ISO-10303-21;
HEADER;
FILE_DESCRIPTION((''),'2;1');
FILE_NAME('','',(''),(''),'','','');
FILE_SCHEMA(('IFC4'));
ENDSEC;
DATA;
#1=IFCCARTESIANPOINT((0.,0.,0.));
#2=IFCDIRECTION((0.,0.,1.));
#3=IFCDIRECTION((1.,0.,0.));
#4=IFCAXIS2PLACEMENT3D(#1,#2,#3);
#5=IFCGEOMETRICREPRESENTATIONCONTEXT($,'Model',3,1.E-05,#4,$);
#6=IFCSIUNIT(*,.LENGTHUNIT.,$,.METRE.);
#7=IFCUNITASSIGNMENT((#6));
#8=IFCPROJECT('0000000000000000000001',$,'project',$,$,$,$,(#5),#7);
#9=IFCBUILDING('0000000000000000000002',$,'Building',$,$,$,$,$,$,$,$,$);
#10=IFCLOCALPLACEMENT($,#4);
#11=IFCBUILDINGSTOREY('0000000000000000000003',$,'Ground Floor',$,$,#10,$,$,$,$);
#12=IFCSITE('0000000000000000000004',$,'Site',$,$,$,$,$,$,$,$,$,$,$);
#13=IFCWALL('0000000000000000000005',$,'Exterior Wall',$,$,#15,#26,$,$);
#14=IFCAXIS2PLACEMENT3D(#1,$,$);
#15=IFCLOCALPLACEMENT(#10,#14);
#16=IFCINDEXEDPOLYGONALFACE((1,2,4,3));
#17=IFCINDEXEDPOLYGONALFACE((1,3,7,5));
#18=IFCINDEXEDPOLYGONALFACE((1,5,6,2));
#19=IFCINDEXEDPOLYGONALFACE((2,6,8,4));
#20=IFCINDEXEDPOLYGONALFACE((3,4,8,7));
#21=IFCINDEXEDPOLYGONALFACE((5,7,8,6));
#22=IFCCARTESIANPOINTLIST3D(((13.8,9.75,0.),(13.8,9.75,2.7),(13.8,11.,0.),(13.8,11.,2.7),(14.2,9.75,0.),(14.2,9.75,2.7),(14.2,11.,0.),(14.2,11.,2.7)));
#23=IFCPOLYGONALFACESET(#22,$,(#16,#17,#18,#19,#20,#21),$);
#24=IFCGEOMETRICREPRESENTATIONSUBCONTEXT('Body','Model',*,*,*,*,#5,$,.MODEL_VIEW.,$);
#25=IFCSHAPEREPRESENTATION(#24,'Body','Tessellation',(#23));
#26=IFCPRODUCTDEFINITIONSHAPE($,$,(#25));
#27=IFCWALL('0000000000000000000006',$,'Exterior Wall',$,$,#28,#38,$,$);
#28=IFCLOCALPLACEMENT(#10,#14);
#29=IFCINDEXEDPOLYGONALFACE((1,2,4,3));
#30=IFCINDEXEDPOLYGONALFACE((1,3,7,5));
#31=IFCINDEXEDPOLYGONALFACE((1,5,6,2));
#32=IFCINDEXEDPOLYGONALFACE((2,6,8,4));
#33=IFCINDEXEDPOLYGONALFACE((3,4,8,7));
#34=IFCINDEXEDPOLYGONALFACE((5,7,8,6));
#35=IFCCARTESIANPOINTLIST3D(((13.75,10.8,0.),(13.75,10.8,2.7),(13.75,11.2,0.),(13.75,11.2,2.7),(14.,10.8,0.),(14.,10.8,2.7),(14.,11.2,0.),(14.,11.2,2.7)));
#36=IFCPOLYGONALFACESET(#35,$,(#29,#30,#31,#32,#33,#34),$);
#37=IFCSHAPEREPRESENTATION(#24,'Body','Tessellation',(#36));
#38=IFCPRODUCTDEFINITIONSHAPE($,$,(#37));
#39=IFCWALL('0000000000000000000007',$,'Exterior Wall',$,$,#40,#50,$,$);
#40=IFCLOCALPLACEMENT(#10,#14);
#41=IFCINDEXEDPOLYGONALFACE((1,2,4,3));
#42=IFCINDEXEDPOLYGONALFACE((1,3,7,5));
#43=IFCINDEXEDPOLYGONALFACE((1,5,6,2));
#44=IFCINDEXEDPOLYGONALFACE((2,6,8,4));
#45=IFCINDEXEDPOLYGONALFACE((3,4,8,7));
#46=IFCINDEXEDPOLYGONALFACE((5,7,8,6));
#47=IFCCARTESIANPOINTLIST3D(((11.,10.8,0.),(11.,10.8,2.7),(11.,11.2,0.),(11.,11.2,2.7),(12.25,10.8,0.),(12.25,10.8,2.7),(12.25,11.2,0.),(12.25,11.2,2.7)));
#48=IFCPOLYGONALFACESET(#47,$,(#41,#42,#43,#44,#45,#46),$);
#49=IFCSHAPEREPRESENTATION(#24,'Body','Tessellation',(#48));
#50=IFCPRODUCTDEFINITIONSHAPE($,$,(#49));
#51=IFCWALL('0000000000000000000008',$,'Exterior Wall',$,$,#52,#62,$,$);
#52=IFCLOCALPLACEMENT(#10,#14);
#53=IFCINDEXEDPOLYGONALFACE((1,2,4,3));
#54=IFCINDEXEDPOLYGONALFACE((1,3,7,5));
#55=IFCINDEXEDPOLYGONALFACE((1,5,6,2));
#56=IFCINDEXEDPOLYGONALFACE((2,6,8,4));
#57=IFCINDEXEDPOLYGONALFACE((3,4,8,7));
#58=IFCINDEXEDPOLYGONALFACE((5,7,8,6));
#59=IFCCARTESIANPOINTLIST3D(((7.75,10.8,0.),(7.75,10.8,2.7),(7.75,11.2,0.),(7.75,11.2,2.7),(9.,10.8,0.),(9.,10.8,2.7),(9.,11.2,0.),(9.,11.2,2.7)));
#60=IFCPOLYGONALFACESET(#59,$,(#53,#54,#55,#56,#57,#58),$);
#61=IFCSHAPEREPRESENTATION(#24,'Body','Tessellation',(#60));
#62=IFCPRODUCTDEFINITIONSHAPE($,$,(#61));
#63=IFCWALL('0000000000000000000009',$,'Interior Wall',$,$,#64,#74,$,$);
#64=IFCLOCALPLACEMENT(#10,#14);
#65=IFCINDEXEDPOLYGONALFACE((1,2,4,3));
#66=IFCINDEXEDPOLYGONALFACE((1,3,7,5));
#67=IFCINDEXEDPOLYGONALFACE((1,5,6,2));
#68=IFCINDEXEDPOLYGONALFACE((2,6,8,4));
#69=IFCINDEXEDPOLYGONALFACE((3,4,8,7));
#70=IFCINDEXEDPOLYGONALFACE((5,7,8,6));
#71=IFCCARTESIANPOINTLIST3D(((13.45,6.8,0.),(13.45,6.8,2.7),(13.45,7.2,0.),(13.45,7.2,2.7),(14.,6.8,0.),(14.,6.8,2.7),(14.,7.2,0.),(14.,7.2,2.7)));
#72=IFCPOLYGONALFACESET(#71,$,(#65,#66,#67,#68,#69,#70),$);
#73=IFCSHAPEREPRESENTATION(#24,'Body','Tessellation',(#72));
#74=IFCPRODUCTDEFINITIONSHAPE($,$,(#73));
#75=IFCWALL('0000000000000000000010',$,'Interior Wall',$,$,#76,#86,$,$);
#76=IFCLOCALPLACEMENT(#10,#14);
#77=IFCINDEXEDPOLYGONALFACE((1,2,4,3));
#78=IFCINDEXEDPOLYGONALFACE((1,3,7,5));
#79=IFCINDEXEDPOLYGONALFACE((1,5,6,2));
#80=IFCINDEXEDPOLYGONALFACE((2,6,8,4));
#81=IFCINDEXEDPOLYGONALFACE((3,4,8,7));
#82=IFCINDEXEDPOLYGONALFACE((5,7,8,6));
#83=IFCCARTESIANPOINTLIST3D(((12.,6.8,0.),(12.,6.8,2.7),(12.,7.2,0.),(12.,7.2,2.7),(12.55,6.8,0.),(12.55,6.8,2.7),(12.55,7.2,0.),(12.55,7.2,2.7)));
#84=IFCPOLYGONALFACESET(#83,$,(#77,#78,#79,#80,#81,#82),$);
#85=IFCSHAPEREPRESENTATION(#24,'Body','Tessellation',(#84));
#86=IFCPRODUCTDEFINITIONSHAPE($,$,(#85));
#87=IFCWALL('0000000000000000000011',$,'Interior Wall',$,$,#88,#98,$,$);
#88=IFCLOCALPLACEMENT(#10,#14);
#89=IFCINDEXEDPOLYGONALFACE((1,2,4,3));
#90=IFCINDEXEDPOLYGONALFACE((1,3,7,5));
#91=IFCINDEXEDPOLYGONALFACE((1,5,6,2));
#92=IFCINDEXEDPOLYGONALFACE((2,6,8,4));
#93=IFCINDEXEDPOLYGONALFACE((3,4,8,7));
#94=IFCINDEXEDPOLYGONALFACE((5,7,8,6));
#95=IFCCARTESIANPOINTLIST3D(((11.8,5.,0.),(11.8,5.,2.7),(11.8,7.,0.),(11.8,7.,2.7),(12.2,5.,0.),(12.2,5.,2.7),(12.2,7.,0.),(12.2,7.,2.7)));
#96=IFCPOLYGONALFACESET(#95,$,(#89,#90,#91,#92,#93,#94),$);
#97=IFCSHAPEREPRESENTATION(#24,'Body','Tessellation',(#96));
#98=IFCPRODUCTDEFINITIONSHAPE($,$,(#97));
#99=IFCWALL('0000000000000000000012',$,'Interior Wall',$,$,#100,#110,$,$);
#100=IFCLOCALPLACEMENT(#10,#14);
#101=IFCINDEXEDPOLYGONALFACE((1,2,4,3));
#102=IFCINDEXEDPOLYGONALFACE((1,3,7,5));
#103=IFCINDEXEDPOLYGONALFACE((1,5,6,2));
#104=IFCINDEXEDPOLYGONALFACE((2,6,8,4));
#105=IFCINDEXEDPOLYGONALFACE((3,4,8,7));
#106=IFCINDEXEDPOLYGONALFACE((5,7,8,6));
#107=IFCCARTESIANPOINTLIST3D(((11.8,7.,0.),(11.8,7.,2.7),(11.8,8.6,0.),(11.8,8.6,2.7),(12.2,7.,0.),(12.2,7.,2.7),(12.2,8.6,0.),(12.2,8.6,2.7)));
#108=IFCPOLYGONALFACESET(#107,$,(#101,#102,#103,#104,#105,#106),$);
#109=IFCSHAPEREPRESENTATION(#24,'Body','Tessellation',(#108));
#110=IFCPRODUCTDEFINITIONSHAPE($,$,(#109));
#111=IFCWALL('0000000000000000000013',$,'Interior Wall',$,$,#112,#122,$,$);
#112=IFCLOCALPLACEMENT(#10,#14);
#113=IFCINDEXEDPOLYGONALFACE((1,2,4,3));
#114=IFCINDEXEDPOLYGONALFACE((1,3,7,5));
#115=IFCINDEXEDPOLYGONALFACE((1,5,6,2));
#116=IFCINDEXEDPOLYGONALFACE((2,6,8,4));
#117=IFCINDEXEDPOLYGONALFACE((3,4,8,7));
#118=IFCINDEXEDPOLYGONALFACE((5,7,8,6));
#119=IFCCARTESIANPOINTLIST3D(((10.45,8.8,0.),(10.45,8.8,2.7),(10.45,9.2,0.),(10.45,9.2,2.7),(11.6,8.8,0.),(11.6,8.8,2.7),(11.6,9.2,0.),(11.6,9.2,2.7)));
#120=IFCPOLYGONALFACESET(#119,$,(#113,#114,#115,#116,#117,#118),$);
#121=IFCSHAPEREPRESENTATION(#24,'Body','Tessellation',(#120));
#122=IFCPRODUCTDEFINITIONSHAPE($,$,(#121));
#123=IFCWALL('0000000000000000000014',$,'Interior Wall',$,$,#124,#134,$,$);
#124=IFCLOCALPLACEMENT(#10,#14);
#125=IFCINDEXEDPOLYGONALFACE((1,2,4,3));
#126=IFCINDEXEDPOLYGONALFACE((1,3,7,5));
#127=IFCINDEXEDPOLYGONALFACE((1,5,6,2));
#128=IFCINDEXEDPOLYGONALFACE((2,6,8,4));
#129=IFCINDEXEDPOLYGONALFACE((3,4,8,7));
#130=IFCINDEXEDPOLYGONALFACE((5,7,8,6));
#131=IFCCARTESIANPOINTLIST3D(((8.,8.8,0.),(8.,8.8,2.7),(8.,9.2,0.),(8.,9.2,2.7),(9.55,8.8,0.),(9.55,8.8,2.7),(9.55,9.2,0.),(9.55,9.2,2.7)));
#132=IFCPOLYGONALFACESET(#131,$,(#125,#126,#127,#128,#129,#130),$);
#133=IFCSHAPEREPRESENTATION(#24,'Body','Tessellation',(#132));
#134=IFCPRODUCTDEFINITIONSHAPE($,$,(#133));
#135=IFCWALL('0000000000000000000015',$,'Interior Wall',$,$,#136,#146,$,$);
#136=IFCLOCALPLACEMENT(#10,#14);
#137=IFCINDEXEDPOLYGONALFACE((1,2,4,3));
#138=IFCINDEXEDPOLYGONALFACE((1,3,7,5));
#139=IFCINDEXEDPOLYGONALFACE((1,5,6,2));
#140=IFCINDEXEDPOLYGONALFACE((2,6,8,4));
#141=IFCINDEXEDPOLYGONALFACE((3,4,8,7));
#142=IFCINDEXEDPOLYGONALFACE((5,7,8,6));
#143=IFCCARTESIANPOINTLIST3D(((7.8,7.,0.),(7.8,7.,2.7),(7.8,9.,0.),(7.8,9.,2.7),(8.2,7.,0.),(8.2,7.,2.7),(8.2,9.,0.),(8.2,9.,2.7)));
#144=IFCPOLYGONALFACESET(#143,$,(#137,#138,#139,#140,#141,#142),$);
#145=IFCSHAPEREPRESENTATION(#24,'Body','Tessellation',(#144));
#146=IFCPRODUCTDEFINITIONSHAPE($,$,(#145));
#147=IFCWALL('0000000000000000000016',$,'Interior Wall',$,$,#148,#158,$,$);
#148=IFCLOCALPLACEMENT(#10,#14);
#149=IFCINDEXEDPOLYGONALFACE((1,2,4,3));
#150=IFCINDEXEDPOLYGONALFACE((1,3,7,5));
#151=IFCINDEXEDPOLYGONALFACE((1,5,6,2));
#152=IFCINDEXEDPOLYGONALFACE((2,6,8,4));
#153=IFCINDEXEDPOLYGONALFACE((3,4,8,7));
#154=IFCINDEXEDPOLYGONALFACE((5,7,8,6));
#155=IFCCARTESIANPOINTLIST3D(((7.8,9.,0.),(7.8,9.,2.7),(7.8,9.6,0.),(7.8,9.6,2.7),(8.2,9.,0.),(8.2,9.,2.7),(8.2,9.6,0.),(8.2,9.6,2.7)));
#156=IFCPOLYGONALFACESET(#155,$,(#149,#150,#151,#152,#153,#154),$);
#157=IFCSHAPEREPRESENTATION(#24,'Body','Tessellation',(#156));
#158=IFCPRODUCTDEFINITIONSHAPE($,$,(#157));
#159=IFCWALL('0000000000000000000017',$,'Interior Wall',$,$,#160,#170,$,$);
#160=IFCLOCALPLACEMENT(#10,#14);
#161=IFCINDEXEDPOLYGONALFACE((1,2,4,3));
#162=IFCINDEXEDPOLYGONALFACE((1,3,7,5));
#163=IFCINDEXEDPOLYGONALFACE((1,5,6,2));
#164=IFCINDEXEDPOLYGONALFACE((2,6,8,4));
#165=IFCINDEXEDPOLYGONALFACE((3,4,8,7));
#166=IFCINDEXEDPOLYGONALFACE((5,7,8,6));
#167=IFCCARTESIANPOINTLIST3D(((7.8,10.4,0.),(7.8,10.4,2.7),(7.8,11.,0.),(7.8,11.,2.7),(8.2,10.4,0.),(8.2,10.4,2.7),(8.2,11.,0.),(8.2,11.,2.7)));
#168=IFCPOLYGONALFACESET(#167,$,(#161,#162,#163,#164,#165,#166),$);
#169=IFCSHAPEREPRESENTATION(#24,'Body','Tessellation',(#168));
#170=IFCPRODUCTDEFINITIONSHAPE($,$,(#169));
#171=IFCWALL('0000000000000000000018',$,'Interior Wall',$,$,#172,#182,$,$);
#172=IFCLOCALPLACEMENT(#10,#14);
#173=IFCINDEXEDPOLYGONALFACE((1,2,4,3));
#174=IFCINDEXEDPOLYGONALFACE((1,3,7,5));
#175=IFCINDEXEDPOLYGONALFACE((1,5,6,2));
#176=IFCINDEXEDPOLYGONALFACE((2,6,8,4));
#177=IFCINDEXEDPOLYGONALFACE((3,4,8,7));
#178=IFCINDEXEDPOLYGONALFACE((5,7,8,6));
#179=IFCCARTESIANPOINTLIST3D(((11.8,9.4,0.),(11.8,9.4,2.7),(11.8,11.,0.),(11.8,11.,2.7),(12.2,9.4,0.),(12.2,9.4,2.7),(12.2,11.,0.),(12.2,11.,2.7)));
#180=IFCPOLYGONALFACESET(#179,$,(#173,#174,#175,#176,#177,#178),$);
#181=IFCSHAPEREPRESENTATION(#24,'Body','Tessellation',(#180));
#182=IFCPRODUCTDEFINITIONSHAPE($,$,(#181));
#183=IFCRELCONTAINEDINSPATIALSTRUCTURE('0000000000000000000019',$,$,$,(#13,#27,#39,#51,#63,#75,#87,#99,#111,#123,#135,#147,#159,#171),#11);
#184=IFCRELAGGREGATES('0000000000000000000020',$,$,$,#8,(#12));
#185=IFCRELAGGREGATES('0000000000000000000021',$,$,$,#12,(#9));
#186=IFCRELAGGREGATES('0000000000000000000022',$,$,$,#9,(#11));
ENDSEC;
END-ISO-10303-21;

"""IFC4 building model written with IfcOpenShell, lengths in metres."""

from ifc_helpers import new_model, si_unit, frame, origin_with_axes, place, context, subcontext, project, spatial, indexed_curve, outline, extrude, element, save


model = new_model("IFC4")

# Units and contexts
model_context = context("Model", 3, precision=1e-05, world=origin_with_axes())
body_context = subcontext(model_context, "Body", "Model", "MODEL_VIEW")
ifc_project = project(units=[si_unit("LENGTHUNIT", "METRE")], contexts=[model_context])

# Site, building, storey
site = spatial("IfcSite", under=ifc_project, Name="Site")
building = spatial("IfcBuilding", under=site, Name="Building")
storey_placement = place(None, origin_with_axes())
storey = spatial("IfcBuildingStorey", under=building, at=storey_placement, Name="Ground Floor")

# Walls
wall_1_placement = place(storey_placement, frame((14.0, 9.75, 0.0), z_axis=(0.0, 0.0, 1.0), x_axis=(0.0, 1.0, 0.0)))
element("IfcWall", 1, at=wall_1_placement, inside=storey, Name="Exterior Wall", context=body_context, shape_type="SweptSolid", body=[
    extrude(outline(indexed_curve([(0.0, 0.0), (0.0, 0.4), (1.25, 0.4), (1.25, 0.0), (0.0, 0.0)], self_intersect=False)), frame((0.0, -0.2, 0.0), z_axis=(0.0, 0.0, 1.0), x_axis=(1.0, 0.0, 0.0)), (0.0, 0.0, 1.0), 2.7),
])
wall_2_placement = place(storey_placement, frame((14.0, 11.0, 0.0), z_axis=(0.0, 0.0, 1.0), x_axis=(-1.0, 0.0, 0.0)))
element("IfcWall", 2, at=wall_2_placement, inside=storey, Name="Exterior Wall", context=body_context, shape_type="SweptSolid", body=[
    extrude(outline(indexed_curve([(0.0, 0.0), (0.0, 0.4), (0.25, 0.4), (0.25, 0.0), (0.0, 0.0)], self_intersect=False)), frame((0.0, -0.2, 0.0), z_axis=(0.0, 0.0, 1.0), x_axis=(1.0, 0.0, 0.0)), (0.0, 0.0, 1.0), 2.7),
])
for number, where, z_axis, x_axis, name in (
    (3, (12.25, 11.0, 0.0), (0.0, 0.0, 1.0), (-1.0, 0.0, 0.0), "Exterior Wall"),
    (4, (9.0, 11.0, 0.0), (0.0, 0.0, 1.0), (-1.0, 0.0, 0.0), "Exterior Wall"),
):
    element("IfcWall", number, at=place(storey_placement, frame(where, z_axis=z_axis, x_axis=x_axis)), inside=storey, Name=name, context=body_context, shape_type="SweptSolid", body=[
        extrude(outline(indexed_curve([(0.0, 0.0), (0.0, 0.4), (1.25, 0.4), (1.25, 0.0), (0.0, 0.0)], self_intersect=False)), frame((0.0, -0.2, 0.0), z_axis=(0.0, 0.0, 1.0), x_axis=(1.0, 0.0, 0.0)), (0.0, 0.0, 1.0), 2.7),
    ])
for number, where, z_axis, x_axis, name in (
    (5, (14.0, 7.0, 0.0), (0.0, 0.0, 1.0), (-1.0, 0.0, 0.0), "Interior Wall"),
    (6, (12.55, 7.0, 0.0), (0.0, 0.0, 1.0), (-1.0, 0.0, 0.0), "Interior Wall"),
):
    element("IfcWall", number, at=place(storey_placement, frame(where, z_axis=z_axis, x_axis=x_axis)), inside=storey, Name=name, context=body_context, shape_type="SweptSolid", body=[
        extrude(outline(indexed_curve([(0.0, 0.0), (0.0, 0.4), (0.55, 0.4), (0.55, 0.0), (0.0, 0.0)], self_intersect=False)), frame((0.0, -0.2, 0.0), z_axis=(0.0, 0.0, 1.0), x_axis=(1.0, 0.0, 0.0)), (0.0, 0.0, 1.0), 2.7),
    ])
wall_3_placement = place(storey_placement, frame((12.0, 7.0, 0.0), z_axis=(0.0, 0.0, 1.0), x_axis=(0.0, -1.0, 0.0)))
element("IfcWall", 7, at=wall_3_placement, inside=storey, Name="Interior Wall", context=body_context, shape_type="SweptSolid", body=[
    extrude(outline(indexed_curve([(0.0, 0.0), (0.0, 0.4), (2.0, 0.4), (2.0, 0.0), (0.0, 0.0)], self_intersect=False)), frame((0.0, -0.2, 0.0), z_axis=(0.0, 0.0, 1.0), x_axis=(1.0, 0.0, 0.0)), (0.0, 0.0, 1.0), 2.7),
])
wall_4_placement = place(storey_placement, frame((12.0, 7.0, 0.0), z_axis=(0.0, 0.0, 1.0), x_axis=(0.0, 1.0, 0.0)))
element("IfcWall", 8, at=wall_4_placement, inside=storey, Name="Interior Wall", context=body_context, shape_type="SweptSolid", body=[
    extrude(outline(indexed_curve([(0.0, 0.0), (0.0, 0.4), (1.6, 0.4), (1.6, 0.0), (0.0, 0.0)], self_intersect=False)), frame((0.0, -0.2, 0.0), z_axis=(0.0, 0.0, 1.0), x_axis=(1.0, 0.0, 0.0)), (0.0, 0.0, 1.0), 2.7),
])
wall_5_placement = place(storey_placement, frame((11.6, 9.0, 0.0), z_axis=(0.0, 0.0, 1.0), x_axis=(-1.0, 0.0, 0.0)))
element("IfcWall", 9, at=wall_5_placement, inside=storey, Name="Interior Wall", context=body_context, shape_type="SweptSolid", body=[
    extrude(outline(indexed_curve([(0.0, 0.0), (0.0, 0.4), (1.15, 0.4), (1.15, 0.0), (0.0, 0.0)], self_intersect=False)), frame((0.0, -0.2, 0.0), z_axis=(0.0, 0.0, 1.0), x_axis=(1.0, 0.0, 0.0)), (0.0, 0.0, 1.0), 2.7),
])
wall_6_placement = place(storey_placement, frame((9.55, 9.0, 0.0), z_axis=(0.0, 0.0, 1.0), x_axis=(-1.0, 0.0, 0.0)))
element("IfcWall", 10, at=wall_6_placement, inside=storey, Name="Interior Wall", context=body_context, shape_type="SweptSolid", body=[
    extrude(outline(indexed_curve([(0.0, 0.0), (0.0, 0.4), (1.55, 0.4), (1.55, 0.0), (0.0, 0.0)], self_intersect=False)), frame((0.0, -0.2, 0.0), z_axis=(0.0, 0.0, 1.0), x_axis=(1.0, 0.0, 0.0)), (0.0, 0.0, 1.0), 2.7),
])
wall_7_placement = place(storey_placement, frame((8.0, 9.0, 0.0), z_axis=(0.0, 0.0, 1.0), x_axis=(0.0, -1.0, 0.0)))
element("IfcWall", 11, at=wall_7_placement, inside=storey, Name="Interior Wall", context=body_context, shape_type="SweptSolid", body=[
    extrude(outline(indexed_curve([(0.0, 0.0), (0.0, 0.4), (2.0, 0.4), (2.0, 0.0), (0.0, 0.0)], self_intersect=False)), frame((0.0, -0.2, 0.0), z_axis=(0.0, 0.0, 1.0), x_axis=(1.0, 0.0, 0.0)), (0.0, 0.0, 1.0), 2.7),
])
for number, where, z_axis, x_axis, name in (
    (12, (8.0, 9.0, 0.0), (0.0, 0.0, 1.0), (0.0, 1.0, 0.0), "Interior Wall"),
    (13, (8.0, 10.4, 0.0), (0.0, 0.0, 1.0), (0.0, 1.0, 0.0), "Interior Wall"),
):
    element("IfcWall", number, at=place(storey_placement, frame(where, z_axis=z_axis, x_axis=x_axis)), inside=storey, Name=name, context=body_context, shape_type="SweptSolid", body=[
        extrude(outline(indexed_curve([(0.0, 0.0), (0.0, 0.4), (0.6, 0.4), (0.6, 0.0), (0.0, 0.0)], self_intersect=False)), frame((0.0, -0.2, 0.0), z_axis=(0.0, 0.0, 1.0), x_axis=(1.0, 0.0, 0.0)), (0.0, 0.0, 1.0), 2.7),
    ])
wall_8_placement = place(storey_placement, frame((12.0, 11.0, 0.0), z_axis=(0.0, 0.0, 1.0), x_axis=(0.0, -1.0, 0.0)))
element("IfcWall", 14, at=wall_8_placement, inside=storey, Name="Interior Wall", context=body_context, shape_type="SweptSolid", body=[
    extrude(outline(indexed_curve([(0.0, 0.0), (0.0, 0.4), (1.6, 0.4), (1.6, 0.0), (0.0, 0.0)], self_intersect=False)), frame((0.0, -0.2, 0.0), z_axis=(0.0, 0.0, 1.0), x_axis=(1.0, 0.0, 0.0)), (0.0, 0.0, 1.0), 2.7),
])

save(model, "model.ifc")
